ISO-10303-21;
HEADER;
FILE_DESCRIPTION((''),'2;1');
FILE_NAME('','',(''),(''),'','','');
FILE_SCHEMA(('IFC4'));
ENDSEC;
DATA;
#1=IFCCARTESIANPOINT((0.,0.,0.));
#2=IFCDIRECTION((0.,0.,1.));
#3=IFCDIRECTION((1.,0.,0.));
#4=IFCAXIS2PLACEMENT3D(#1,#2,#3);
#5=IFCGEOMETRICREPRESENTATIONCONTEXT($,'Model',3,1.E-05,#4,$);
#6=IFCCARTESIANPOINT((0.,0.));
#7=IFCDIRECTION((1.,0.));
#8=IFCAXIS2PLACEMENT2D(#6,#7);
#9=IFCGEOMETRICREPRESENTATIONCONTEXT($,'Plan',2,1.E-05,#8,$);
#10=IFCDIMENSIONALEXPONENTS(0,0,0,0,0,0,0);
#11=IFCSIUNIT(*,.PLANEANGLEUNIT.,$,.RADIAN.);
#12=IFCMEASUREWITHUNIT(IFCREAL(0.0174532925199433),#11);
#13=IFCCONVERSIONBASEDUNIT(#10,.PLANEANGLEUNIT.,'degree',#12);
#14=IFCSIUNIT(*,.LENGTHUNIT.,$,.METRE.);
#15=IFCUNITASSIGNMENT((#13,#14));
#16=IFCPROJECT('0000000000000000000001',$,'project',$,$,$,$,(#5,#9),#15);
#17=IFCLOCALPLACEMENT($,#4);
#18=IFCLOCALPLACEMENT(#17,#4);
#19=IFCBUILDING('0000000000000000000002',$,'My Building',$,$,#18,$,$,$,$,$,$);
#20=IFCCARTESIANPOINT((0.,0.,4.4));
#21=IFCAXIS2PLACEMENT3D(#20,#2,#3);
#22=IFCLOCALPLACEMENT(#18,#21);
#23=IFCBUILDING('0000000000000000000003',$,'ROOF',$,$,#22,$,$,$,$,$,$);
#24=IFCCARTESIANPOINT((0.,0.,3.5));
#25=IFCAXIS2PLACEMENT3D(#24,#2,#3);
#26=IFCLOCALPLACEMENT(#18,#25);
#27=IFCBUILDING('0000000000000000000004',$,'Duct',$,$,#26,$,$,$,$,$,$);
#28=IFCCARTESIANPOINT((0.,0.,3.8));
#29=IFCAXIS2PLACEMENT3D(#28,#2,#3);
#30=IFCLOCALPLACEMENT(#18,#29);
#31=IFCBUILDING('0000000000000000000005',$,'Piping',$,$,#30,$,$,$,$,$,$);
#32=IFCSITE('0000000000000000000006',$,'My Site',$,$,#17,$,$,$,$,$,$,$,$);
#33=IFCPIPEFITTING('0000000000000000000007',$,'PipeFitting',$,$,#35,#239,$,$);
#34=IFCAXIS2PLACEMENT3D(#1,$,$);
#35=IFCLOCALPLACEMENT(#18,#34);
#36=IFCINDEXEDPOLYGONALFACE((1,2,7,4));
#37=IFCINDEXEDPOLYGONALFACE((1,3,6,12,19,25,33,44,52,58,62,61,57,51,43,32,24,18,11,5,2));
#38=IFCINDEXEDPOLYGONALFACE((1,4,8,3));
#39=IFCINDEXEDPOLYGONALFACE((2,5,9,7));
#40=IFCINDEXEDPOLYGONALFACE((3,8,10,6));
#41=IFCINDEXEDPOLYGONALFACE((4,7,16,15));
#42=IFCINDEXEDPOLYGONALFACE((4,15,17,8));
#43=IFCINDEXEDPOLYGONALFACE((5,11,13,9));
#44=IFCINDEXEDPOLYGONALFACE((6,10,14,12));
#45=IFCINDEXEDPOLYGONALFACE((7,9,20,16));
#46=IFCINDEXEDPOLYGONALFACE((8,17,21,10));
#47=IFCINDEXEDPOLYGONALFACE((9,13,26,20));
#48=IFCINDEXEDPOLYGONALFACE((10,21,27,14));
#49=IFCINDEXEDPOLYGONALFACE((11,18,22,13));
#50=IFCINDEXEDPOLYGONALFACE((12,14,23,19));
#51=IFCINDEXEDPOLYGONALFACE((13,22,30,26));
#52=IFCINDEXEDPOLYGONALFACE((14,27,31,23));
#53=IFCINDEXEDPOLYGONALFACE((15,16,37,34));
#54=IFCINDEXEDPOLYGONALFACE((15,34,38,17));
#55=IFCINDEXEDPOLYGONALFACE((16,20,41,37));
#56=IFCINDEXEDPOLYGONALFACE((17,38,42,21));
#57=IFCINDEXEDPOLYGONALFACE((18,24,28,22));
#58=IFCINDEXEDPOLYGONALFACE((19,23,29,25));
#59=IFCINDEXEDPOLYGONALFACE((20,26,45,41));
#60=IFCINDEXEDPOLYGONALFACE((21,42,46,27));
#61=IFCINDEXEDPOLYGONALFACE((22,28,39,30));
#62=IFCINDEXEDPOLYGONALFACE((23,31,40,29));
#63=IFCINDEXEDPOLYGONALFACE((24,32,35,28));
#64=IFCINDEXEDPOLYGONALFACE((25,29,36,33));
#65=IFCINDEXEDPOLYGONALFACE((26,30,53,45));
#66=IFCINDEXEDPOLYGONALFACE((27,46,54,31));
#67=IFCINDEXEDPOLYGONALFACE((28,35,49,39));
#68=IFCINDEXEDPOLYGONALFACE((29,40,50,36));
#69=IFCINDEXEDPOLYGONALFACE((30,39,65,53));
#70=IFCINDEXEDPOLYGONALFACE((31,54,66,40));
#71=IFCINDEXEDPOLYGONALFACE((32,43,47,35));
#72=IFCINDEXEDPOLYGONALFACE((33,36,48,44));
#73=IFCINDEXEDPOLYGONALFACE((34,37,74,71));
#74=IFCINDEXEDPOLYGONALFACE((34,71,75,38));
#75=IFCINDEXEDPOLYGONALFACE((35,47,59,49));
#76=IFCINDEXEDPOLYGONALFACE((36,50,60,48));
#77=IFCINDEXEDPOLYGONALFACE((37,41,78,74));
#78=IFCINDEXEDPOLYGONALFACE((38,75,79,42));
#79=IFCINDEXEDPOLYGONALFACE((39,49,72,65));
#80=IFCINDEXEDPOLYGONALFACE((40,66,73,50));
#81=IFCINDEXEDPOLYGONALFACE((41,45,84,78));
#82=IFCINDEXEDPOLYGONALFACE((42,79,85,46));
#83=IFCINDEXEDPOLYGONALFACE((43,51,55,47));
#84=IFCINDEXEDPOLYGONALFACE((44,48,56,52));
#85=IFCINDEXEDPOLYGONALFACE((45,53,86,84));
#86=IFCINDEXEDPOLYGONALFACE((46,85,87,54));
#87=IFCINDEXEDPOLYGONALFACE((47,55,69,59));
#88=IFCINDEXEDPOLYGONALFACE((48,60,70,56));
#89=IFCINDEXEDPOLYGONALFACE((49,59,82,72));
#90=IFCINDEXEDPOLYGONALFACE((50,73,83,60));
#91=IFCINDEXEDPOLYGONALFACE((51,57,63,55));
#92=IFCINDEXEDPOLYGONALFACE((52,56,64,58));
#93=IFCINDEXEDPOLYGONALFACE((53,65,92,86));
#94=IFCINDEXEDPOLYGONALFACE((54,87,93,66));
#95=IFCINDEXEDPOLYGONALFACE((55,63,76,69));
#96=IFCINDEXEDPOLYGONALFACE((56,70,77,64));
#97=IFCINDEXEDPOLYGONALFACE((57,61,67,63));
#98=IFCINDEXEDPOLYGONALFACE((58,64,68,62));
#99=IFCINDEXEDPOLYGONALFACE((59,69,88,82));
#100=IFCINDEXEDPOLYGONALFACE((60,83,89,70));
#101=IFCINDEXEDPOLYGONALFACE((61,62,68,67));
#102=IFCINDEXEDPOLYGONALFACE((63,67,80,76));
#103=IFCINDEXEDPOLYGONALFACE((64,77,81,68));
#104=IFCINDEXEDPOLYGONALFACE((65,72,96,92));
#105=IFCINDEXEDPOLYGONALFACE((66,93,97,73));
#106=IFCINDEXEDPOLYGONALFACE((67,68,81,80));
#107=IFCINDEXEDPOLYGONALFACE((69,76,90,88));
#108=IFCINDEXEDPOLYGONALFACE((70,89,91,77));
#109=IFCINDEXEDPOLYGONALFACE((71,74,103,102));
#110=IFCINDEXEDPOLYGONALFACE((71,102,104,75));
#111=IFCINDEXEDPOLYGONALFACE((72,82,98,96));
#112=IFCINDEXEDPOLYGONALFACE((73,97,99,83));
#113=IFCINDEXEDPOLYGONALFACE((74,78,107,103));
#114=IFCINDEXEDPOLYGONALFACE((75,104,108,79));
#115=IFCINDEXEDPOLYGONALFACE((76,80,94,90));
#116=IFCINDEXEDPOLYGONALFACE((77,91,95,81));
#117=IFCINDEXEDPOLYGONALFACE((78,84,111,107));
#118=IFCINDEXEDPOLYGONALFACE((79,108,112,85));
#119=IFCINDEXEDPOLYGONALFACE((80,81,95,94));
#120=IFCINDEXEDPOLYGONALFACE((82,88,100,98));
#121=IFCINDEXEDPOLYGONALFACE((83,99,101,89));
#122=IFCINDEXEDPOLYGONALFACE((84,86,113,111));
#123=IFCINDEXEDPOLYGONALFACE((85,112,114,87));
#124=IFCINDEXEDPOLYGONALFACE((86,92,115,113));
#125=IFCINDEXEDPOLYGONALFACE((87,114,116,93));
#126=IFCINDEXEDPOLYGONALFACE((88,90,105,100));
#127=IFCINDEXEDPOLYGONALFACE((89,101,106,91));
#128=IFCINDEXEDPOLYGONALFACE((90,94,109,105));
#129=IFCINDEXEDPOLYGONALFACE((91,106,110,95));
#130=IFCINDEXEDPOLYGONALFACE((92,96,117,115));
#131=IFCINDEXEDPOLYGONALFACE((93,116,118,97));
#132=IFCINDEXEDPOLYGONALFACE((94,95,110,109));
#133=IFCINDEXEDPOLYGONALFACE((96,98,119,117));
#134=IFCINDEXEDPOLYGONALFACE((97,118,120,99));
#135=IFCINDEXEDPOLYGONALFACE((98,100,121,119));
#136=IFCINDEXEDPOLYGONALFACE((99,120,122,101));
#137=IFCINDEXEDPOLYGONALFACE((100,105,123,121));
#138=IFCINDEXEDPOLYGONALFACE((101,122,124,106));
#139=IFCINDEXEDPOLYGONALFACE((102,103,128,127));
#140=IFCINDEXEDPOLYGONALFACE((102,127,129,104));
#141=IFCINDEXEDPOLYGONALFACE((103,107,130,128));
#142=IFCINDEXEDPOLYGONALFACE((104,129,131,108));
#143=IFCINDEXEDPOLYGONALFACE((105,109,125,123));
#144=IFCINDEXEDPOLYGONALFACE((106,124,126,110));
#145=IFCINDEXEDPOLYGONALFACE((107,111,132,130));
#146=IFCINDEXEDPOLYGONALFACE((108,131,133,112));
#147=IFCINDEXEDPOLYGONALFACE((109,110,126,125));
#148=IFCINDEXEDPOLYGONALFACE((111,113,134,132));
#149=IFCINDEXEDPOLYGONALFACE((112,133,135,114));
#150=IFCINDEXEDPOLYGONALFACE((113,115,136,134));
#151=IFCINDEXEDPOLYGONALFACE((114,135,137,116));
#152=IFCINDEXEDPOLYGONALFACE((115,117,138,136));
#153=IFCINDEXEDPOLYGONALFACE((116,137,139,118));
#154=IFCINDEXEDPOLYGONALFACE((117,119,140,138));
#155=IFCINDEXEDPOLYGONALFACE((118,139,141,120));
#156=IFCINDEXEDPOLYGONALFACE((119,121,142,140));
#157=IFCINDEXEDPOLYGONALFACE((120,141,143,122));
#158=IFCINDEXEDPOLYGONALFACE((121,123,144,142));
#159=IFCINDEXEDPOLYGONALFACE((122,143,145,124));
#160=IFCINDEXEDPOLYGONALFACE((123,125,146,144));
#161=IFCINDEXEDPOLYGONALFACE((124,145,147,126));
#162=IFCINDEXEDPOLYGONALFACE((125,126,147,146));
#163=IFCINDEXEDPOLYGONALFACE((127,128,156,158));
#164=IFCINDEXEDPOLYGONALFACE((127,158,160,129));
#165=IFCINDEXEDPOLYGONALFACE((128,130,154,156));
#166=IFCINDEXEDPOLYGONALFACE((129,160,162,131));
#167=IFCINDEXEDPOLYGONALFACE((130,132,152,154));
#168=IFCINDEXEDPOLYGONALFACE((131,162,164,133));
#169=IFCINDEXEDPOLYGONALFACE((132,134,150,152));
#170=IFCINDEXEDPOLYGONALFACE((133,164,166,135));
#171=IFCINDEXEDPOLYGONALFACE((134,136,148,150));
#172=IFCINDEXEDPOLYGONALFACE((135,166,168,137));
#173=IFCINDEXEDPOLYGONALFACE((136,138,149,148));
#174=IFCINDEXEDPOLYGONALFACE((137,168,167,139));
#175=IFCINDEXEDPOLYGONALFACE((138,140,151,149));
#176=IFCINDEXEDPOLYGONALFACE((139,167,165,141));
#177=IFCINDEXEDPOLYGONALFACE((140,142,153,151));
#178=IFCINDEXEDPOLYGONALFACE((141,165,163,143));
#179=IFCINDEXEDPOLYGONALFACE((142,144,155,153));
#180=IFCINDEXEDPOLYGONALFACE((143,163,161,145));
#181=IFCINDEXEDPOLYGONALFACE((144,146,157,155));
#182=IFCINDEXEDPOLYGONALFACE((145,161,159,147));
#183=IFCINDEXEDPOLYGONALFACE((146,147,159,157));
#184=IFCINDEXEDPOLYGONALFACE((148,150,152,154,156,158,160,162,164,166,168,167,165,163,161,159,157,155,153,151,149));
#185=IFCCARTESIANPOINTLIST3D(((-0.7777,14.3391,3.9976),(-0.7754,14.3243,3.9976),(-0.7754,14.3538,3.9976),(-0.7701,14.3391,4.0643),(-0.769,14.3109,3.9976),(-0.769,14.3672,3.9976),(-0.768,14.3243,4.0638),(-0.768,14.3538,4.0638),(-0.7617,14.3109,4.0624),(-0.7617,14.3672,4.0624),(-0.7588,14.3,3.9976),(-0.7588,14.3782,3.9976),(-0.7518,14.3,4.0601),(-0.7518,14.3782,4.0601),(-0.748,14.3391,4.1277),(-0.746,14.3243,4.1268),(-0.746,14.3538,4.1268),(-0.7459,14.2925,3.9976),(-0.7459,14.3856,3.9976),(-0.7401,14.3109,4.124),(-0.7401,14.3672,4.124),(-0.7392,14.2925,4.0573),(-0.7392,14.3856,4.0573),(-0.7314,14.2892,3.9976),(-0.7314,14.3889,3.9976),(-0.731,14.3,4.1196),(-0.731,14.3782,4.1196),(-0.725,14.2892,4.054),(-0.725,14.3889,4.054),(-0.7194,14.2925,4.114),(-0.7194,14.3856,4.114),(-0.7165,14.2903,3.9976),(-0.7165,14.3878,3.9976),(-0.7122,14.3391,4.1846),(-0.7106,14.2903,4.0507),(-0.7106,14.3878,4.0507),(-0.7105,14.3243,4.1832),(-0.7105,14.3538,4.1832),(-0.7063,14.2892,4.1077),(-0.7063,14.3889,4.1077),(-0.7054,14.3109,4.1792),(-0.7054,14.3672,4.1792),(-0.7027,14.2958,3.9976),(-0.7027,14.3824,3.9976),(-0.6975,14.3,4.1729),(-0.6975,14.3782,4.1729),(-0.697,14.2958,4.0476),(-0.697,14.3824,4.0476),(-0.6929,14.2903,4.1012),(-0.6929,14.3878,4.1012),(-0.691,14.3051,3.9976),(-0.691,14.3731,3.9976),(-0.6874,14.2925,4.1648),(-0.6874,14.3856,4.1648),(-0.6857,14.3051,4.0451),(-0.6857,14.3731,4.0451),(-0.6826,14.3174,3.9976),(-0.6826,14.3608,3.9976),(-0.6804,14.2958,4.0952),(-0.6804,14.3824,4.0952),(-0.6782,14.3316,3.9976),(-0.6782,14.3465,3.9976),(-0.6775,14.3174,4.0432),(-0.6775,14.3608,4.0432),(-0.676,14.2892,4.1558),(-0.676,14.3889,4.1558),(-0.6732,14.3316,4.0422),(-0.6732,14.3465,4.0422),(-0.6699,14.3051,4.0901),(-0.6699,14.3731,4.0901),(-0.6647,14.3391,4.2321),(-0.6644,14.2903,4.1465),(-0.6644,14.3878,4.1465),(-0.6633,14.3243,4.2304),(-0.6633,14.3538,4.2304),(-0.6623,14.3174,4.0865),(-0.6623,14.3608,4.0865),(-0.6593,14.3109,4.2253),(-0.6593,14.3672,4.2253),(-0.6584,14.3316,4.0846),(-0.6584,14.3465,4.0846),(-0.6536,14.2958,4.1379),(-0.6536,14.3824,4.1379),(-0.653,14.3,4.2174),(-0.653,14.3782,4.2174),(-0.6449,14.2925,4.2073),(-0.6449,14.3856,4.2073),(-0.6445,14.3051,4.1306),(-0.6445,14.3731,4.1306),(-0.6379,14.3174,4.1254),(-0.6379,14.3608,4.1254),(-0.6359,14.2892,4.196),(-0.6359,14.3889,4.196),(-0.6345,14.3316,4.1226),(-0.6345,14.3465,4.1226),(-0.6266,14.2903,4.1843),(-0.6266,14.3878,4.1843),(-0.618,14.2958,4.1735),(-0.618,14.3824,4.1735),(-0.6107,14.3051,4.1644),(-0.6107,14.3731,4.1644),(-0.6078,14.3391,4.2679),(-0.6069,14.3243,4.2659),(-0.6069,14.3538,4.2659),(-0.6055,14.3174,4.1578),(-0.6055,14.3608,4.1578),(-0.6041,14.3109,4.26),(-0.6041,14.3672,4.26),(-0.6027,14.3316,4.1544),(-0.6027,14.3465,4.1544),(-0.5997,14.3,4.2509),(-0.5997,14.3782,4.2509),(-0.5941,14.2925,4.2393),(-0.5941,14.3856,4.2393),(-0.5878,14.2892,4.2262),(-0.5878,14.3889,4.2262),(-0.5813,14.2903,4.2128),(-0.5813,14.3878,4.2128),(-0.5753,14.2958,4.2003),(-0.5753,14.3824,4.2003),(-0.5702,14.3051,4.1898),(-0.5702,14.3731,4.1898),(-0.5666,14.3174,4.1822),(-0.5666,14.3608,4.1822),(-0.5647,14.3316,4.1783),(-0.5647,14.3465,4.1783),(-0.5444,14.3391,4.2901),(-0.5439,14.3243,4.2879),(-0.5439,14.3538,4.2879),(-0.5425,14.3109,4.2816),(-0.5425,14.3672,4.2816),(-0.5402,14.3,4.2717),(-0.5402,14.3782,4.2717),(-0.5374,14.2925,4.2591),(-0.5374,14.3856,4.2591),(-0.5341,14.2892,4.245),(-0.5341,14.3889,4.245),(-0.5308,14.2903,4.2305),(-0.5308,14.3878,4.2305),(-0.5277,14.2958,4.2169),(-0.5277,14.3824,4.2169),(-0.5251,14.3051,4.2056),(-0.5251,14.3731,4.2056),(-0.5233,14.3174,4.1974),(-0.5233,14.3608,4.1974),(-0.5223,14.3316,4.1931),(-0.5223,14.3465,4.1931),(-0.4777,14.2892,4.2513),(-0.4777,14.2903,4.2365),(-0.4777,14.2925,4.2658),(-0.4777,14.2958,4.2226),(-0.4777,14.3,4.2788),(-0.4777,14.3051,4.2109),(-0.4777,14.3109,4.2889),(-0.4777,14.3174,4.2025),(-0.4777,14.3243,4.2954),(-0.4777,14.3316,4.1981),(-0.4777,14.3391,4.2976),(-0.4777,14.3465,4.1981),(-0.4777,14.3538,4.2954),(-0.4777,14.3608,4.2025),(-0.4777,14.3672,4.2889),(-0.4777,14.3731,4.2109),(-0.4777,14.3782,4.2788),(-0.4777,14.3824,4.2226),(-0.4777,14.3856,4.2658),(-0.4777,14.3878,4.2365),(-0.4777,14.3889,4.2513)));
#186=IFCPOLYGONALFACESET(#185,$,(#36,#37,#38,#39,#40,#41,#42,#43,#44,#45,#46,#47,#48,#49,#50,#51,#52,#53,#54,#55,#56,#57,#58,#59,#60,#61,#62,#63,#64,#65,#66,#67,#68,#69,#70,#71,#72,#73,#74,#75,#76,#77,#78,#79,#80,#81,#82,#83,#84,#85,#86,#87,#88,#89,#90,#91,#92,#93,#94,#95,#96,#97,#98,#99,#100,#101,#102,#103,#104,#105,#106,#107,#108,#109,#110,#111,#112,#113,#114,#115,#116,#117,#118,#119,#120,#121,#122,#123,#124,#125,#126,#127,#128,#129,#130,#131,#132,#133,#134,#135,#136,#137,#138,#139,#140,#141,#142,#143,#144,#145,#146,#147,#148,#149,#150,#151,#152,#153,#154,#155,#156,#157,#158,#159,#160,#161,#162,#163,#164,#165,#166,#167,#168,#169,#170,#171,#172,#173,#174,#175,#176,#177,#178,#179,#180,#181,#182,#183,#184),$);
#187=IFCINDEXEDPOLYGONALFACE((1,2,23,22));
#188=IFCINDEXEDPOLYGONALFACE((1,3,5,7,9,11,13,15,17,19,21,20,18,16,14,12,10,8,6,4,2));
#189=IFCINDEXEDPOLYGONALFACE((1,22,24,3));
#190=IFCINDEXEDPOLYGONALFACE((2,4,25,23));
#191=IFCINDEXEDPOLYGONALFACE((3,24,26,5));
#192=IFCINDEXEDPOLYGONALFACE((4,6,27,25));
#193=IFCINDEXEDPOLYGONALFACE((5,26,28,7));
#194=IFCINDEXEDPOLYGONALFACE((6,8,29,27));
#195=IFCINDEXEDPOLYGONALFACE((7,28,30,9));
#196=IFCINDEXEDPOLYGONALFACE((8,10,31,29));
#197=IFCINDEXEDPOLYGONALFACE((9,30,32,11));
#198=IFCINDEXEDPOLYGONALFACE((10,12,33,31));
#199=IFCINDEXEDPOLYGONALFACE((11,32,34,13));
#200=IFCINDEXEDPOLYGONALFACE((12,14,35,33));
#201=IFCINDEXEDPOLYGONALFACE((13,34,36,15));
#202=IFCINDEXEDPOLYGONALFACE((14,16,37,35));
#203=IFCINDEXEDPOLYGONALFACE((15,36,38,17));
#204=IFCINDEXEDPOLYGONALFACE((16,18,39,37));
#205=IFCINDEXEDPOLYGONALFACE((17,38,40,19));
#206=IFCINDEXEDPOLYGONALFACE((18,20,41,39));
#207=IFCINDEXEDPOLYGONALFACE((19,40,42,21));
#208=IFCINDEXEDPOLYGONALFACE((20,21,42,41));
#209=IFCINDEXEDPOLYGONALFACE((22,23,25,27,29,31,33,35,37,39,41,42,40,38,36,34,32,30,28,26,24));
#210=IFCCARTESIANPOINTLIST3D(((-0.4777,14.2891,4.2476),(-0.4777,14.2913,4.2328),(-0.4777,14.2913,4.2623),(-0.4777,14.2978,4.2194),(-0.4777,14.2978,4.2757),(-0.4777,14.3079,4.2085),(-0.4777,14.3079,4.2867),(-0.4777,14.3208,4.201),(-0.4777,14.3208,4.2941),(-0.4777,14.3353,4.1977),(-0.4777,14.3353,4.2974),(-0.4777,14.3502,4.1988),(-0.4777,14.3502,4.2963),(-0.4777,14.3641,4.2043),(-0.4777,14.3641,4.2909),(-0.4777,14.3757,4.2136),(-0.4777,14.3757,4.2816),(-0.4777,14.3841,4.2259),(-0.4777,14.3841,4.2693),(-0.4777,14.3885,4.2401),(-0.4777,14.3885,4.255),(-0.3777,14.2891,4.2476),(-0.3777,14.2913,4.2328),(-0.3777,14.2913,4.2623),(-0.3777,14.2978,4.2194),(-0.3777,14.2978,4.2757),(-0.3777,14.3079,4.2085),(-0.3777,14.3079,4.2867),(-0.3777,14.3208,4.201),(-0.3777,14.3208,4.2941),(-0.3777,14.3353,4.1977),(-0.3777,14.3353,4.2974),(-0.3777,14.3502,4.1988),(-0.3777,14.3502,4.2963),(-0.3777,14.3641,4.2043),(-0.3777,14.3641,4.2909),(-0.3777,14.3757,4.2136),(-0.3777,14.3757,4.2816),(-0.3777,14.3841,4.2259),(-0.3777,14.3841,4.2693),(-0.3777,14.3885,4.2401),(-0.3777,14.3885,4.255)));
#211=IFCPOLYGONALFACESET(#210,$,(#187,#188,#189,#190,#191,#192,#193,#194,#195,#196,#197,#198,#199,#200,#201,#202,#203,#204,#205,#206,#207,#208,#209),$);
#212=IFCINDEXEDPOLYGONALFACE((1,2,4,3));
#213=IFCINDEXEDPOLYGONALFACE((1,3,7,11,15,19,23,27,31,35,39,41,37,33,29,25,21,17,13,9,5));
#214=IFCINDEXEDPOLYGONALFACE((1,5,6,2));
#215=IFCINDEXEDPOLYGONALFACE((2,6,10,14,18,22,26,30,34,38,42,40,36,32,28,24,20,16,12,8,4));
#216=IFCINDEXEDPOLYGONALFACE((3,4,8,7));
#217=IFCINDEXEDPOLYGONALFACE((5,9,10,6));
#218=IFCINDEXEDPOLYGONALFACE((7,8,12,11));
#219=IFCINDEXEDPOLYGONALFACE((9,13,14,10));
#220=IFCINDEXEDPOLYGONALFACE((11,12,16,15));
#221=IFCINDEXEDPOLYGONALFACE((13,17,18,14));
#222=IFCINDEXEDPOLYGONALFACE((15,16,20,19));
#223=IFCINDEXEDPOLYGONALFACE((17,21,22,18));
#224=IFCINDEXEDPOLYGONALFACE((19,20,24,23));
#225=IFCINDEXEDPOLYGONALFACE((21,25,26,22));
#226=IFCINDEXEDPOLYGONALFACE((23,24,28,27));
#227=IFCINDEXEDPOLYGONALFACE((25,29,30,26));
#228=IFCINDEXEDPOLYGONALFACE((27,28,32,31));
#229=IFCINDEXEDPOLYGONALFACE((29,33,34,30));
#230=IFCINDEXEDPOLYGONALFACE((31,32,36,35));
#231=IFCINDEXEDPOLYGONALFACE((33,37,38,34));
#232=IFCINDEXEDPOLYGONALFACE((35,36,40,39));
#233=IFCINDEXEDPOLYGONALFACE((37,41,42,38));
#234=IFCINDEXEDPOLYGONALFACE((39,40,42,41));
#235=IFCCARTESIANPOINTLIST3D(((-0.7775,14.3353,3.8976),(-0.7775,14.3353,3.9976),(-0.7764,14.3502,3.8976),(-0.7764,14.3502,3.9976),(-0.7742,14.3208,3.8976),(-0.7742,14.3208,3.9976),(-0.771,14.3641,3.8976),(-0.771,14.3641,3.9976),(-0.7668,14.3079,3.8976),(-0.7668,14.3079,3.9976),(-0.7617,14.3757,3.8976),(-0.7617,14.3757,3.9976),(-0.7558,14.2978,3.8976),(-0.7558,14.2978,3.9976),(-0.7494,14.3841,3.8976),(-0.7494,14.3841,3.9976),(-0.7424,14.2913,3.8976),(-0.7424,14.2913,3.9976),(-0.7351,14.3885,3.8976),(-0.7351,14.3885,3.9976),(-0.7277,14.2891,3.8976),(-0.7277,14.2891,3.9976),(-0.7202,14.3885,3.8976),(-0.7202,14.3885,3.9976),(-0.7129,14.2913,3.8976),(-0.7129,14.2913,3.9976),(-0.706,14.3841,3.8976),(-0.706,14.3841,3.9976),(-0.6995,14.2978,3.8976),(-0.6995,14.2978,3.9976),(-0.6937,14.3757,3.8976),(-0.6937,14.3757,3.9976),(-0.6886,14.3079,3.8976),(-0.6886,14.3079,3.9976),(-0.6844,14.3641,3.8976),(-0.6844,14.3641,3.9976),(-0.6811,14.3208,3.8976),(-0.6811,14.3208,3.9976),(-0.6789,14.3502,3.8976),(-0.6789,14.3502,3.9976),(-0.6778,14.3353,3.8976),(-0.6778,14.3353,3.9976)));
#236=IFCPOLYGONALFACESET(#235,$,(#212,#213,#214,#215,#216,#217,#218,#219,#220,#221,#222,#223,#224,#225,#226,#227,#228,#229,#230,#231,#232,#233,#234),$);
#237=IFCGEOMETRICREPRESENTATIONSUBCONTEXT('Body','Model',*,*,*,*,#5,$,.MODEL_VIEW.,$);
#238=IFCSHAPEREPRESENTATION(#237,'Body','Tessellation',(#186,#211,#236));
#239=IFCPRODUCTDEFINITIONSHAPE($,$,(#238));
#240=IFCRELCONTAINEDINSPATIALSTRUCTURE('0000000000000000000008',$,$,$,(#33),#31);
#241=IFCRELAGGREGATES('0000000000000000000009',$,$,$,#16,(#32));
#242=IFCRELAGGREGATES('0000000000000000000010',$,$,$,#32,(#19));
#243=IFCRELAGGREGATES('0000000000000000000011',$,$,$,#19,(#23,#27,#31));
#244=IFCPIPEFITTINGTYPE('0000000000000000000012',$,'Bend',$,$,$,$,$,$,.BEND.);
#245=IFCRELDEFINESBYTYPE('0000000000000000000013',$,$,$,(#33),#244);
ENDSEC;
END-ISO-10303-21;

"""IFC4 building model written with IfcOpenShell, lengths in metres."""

from ifc_helpers import new_model, entity, si_unit, converted_unit, frame, origin_with_axes, origin_2d_with_axis, place, context, subcontext, project, spatial, circle, extrude, source, transform, mapped, type_object, type_shapes, element, save


model = new_model("IFC4")

# Units and contexts
model_context = context("Model", 3, precision=1e-05, world=origin_with_axes())
plan_context = context("Plan", 2, precision=1e-05, world=origin_2d_with_axis())
body_context_1 = subcontext(model_context, "Body", "Model", "MODEL_VIEW")
ifc_project = project(units=[converted_unit("PLANEANGLEUNIT", "degree", entity("IfcReal", 0.0174532925199433), si_unit("PLANEANGLEUNIT", "RADIAN"), dimensions=[0, 0, 0, 0, 0, 0, 0]), si_unit("LENGTHUNIT", "METRE")], contexts=[model_context, plan_context])

# Site, building
site_placement = place(None, origin_with_axes())
site = spatial("IfcSite", under=ifc_project, at=site_placement, Name="My Site")
building_1_placement = place(site_placement, origin_with_axes())
building_1 = spatial("IfcBuilding", under=site, at=building_1_placement, Name="My Building")

# Shared definitions
building_2_placement = place(building_1_placement, frame((0.0, 0.0, 4.4), z_axis=(0.0, 0.0, 1.0), x_axis=(1.0, 0.0, 0.0)))
building_2 = spatial("IfcBuilding", under=building_1, at=building_2_placement, Name="ROOF")

# Shared definitions
building_3_placement = place(building_1_placement, frame((0.0, 0.0, 3.5), z_axis=(0.0, 0.0, 1.0), x_axis=(1.0, 0.0, 0.0)))
building_3 = spatial("IfcBuilding", under=building_1, at=building_3_placement, Name="Duct")

# Shared definitions
building_4_placement = place(building_1_placement, frame((0.0, 0.0, 3.8), z_axis=(0.0, 0.0, 1.0), x_axis=(1.0, 0.0, 0.0)))
building_4 = spatial("IfcBuilding", under=building_1, at=building_4_placement, Name="Piping")

# Pipe fitting
pipe_fitting_type_1 = type_object("IfcPipeFittingType", Name="Bend", PredefinedType="BEND")
shared_shape_1 = source(origin_with_axes(), body_context_1, "Body", "SolidModel", [
    entity("IfcSweptDiskSolid", entity("IfcIndexedPolyCurve", entity("IfcCartesianPointList3D", [[0.0, 0.0, 0.1], [0.0, -0.0732, 0.2768], [0.0, -0.25, 0.35]]), [entity("IfcArcIndex", [1, 2, 3])]), 0.05),
    extrude(circle(Radius=0.05), origin_with_axes(), (0.0, 0.0, 1.0), 0.1),
    extrude(circle(Radius=0.05), frame((0.0, -0.25, 0.35), z_axis=(0.0, -1.0, -0.000001), x_axis=(1.0, 0.0, 0.0)), (0.0, 0.0, 1.0), 0.1),
])
type_shapes(pipe_fitting_type_1, [shared_shape_1])
for number, where, z_axis, x_axis, name in (
    (1, (-0.3777, 14.3391, 0.4476), (-1.0, 0.0, 0.0), (0.0, -1.0, 0.0), "PipeFitting"),
):
    element("IfcPipeFitting", number, at=place(building_4_placement, frame(where, z_axis=z_axis, x_axis=x_axis)), inside=building_4, type_object=pipe_fitting_type_1, Name=name, context=body_context_1, shape_type="MappedRepresentation", body=[
        mapped(shared_shape_1, transform((0.0, 0.0, 0.0), x_axis=(1.0, 0.0, 0.0), y_axis=(0.0, 1.0, 0.0), z_axis=(0.0, 0.0, 1.0), scale=1.0)),
    ])

save(model, "model.ifc")
